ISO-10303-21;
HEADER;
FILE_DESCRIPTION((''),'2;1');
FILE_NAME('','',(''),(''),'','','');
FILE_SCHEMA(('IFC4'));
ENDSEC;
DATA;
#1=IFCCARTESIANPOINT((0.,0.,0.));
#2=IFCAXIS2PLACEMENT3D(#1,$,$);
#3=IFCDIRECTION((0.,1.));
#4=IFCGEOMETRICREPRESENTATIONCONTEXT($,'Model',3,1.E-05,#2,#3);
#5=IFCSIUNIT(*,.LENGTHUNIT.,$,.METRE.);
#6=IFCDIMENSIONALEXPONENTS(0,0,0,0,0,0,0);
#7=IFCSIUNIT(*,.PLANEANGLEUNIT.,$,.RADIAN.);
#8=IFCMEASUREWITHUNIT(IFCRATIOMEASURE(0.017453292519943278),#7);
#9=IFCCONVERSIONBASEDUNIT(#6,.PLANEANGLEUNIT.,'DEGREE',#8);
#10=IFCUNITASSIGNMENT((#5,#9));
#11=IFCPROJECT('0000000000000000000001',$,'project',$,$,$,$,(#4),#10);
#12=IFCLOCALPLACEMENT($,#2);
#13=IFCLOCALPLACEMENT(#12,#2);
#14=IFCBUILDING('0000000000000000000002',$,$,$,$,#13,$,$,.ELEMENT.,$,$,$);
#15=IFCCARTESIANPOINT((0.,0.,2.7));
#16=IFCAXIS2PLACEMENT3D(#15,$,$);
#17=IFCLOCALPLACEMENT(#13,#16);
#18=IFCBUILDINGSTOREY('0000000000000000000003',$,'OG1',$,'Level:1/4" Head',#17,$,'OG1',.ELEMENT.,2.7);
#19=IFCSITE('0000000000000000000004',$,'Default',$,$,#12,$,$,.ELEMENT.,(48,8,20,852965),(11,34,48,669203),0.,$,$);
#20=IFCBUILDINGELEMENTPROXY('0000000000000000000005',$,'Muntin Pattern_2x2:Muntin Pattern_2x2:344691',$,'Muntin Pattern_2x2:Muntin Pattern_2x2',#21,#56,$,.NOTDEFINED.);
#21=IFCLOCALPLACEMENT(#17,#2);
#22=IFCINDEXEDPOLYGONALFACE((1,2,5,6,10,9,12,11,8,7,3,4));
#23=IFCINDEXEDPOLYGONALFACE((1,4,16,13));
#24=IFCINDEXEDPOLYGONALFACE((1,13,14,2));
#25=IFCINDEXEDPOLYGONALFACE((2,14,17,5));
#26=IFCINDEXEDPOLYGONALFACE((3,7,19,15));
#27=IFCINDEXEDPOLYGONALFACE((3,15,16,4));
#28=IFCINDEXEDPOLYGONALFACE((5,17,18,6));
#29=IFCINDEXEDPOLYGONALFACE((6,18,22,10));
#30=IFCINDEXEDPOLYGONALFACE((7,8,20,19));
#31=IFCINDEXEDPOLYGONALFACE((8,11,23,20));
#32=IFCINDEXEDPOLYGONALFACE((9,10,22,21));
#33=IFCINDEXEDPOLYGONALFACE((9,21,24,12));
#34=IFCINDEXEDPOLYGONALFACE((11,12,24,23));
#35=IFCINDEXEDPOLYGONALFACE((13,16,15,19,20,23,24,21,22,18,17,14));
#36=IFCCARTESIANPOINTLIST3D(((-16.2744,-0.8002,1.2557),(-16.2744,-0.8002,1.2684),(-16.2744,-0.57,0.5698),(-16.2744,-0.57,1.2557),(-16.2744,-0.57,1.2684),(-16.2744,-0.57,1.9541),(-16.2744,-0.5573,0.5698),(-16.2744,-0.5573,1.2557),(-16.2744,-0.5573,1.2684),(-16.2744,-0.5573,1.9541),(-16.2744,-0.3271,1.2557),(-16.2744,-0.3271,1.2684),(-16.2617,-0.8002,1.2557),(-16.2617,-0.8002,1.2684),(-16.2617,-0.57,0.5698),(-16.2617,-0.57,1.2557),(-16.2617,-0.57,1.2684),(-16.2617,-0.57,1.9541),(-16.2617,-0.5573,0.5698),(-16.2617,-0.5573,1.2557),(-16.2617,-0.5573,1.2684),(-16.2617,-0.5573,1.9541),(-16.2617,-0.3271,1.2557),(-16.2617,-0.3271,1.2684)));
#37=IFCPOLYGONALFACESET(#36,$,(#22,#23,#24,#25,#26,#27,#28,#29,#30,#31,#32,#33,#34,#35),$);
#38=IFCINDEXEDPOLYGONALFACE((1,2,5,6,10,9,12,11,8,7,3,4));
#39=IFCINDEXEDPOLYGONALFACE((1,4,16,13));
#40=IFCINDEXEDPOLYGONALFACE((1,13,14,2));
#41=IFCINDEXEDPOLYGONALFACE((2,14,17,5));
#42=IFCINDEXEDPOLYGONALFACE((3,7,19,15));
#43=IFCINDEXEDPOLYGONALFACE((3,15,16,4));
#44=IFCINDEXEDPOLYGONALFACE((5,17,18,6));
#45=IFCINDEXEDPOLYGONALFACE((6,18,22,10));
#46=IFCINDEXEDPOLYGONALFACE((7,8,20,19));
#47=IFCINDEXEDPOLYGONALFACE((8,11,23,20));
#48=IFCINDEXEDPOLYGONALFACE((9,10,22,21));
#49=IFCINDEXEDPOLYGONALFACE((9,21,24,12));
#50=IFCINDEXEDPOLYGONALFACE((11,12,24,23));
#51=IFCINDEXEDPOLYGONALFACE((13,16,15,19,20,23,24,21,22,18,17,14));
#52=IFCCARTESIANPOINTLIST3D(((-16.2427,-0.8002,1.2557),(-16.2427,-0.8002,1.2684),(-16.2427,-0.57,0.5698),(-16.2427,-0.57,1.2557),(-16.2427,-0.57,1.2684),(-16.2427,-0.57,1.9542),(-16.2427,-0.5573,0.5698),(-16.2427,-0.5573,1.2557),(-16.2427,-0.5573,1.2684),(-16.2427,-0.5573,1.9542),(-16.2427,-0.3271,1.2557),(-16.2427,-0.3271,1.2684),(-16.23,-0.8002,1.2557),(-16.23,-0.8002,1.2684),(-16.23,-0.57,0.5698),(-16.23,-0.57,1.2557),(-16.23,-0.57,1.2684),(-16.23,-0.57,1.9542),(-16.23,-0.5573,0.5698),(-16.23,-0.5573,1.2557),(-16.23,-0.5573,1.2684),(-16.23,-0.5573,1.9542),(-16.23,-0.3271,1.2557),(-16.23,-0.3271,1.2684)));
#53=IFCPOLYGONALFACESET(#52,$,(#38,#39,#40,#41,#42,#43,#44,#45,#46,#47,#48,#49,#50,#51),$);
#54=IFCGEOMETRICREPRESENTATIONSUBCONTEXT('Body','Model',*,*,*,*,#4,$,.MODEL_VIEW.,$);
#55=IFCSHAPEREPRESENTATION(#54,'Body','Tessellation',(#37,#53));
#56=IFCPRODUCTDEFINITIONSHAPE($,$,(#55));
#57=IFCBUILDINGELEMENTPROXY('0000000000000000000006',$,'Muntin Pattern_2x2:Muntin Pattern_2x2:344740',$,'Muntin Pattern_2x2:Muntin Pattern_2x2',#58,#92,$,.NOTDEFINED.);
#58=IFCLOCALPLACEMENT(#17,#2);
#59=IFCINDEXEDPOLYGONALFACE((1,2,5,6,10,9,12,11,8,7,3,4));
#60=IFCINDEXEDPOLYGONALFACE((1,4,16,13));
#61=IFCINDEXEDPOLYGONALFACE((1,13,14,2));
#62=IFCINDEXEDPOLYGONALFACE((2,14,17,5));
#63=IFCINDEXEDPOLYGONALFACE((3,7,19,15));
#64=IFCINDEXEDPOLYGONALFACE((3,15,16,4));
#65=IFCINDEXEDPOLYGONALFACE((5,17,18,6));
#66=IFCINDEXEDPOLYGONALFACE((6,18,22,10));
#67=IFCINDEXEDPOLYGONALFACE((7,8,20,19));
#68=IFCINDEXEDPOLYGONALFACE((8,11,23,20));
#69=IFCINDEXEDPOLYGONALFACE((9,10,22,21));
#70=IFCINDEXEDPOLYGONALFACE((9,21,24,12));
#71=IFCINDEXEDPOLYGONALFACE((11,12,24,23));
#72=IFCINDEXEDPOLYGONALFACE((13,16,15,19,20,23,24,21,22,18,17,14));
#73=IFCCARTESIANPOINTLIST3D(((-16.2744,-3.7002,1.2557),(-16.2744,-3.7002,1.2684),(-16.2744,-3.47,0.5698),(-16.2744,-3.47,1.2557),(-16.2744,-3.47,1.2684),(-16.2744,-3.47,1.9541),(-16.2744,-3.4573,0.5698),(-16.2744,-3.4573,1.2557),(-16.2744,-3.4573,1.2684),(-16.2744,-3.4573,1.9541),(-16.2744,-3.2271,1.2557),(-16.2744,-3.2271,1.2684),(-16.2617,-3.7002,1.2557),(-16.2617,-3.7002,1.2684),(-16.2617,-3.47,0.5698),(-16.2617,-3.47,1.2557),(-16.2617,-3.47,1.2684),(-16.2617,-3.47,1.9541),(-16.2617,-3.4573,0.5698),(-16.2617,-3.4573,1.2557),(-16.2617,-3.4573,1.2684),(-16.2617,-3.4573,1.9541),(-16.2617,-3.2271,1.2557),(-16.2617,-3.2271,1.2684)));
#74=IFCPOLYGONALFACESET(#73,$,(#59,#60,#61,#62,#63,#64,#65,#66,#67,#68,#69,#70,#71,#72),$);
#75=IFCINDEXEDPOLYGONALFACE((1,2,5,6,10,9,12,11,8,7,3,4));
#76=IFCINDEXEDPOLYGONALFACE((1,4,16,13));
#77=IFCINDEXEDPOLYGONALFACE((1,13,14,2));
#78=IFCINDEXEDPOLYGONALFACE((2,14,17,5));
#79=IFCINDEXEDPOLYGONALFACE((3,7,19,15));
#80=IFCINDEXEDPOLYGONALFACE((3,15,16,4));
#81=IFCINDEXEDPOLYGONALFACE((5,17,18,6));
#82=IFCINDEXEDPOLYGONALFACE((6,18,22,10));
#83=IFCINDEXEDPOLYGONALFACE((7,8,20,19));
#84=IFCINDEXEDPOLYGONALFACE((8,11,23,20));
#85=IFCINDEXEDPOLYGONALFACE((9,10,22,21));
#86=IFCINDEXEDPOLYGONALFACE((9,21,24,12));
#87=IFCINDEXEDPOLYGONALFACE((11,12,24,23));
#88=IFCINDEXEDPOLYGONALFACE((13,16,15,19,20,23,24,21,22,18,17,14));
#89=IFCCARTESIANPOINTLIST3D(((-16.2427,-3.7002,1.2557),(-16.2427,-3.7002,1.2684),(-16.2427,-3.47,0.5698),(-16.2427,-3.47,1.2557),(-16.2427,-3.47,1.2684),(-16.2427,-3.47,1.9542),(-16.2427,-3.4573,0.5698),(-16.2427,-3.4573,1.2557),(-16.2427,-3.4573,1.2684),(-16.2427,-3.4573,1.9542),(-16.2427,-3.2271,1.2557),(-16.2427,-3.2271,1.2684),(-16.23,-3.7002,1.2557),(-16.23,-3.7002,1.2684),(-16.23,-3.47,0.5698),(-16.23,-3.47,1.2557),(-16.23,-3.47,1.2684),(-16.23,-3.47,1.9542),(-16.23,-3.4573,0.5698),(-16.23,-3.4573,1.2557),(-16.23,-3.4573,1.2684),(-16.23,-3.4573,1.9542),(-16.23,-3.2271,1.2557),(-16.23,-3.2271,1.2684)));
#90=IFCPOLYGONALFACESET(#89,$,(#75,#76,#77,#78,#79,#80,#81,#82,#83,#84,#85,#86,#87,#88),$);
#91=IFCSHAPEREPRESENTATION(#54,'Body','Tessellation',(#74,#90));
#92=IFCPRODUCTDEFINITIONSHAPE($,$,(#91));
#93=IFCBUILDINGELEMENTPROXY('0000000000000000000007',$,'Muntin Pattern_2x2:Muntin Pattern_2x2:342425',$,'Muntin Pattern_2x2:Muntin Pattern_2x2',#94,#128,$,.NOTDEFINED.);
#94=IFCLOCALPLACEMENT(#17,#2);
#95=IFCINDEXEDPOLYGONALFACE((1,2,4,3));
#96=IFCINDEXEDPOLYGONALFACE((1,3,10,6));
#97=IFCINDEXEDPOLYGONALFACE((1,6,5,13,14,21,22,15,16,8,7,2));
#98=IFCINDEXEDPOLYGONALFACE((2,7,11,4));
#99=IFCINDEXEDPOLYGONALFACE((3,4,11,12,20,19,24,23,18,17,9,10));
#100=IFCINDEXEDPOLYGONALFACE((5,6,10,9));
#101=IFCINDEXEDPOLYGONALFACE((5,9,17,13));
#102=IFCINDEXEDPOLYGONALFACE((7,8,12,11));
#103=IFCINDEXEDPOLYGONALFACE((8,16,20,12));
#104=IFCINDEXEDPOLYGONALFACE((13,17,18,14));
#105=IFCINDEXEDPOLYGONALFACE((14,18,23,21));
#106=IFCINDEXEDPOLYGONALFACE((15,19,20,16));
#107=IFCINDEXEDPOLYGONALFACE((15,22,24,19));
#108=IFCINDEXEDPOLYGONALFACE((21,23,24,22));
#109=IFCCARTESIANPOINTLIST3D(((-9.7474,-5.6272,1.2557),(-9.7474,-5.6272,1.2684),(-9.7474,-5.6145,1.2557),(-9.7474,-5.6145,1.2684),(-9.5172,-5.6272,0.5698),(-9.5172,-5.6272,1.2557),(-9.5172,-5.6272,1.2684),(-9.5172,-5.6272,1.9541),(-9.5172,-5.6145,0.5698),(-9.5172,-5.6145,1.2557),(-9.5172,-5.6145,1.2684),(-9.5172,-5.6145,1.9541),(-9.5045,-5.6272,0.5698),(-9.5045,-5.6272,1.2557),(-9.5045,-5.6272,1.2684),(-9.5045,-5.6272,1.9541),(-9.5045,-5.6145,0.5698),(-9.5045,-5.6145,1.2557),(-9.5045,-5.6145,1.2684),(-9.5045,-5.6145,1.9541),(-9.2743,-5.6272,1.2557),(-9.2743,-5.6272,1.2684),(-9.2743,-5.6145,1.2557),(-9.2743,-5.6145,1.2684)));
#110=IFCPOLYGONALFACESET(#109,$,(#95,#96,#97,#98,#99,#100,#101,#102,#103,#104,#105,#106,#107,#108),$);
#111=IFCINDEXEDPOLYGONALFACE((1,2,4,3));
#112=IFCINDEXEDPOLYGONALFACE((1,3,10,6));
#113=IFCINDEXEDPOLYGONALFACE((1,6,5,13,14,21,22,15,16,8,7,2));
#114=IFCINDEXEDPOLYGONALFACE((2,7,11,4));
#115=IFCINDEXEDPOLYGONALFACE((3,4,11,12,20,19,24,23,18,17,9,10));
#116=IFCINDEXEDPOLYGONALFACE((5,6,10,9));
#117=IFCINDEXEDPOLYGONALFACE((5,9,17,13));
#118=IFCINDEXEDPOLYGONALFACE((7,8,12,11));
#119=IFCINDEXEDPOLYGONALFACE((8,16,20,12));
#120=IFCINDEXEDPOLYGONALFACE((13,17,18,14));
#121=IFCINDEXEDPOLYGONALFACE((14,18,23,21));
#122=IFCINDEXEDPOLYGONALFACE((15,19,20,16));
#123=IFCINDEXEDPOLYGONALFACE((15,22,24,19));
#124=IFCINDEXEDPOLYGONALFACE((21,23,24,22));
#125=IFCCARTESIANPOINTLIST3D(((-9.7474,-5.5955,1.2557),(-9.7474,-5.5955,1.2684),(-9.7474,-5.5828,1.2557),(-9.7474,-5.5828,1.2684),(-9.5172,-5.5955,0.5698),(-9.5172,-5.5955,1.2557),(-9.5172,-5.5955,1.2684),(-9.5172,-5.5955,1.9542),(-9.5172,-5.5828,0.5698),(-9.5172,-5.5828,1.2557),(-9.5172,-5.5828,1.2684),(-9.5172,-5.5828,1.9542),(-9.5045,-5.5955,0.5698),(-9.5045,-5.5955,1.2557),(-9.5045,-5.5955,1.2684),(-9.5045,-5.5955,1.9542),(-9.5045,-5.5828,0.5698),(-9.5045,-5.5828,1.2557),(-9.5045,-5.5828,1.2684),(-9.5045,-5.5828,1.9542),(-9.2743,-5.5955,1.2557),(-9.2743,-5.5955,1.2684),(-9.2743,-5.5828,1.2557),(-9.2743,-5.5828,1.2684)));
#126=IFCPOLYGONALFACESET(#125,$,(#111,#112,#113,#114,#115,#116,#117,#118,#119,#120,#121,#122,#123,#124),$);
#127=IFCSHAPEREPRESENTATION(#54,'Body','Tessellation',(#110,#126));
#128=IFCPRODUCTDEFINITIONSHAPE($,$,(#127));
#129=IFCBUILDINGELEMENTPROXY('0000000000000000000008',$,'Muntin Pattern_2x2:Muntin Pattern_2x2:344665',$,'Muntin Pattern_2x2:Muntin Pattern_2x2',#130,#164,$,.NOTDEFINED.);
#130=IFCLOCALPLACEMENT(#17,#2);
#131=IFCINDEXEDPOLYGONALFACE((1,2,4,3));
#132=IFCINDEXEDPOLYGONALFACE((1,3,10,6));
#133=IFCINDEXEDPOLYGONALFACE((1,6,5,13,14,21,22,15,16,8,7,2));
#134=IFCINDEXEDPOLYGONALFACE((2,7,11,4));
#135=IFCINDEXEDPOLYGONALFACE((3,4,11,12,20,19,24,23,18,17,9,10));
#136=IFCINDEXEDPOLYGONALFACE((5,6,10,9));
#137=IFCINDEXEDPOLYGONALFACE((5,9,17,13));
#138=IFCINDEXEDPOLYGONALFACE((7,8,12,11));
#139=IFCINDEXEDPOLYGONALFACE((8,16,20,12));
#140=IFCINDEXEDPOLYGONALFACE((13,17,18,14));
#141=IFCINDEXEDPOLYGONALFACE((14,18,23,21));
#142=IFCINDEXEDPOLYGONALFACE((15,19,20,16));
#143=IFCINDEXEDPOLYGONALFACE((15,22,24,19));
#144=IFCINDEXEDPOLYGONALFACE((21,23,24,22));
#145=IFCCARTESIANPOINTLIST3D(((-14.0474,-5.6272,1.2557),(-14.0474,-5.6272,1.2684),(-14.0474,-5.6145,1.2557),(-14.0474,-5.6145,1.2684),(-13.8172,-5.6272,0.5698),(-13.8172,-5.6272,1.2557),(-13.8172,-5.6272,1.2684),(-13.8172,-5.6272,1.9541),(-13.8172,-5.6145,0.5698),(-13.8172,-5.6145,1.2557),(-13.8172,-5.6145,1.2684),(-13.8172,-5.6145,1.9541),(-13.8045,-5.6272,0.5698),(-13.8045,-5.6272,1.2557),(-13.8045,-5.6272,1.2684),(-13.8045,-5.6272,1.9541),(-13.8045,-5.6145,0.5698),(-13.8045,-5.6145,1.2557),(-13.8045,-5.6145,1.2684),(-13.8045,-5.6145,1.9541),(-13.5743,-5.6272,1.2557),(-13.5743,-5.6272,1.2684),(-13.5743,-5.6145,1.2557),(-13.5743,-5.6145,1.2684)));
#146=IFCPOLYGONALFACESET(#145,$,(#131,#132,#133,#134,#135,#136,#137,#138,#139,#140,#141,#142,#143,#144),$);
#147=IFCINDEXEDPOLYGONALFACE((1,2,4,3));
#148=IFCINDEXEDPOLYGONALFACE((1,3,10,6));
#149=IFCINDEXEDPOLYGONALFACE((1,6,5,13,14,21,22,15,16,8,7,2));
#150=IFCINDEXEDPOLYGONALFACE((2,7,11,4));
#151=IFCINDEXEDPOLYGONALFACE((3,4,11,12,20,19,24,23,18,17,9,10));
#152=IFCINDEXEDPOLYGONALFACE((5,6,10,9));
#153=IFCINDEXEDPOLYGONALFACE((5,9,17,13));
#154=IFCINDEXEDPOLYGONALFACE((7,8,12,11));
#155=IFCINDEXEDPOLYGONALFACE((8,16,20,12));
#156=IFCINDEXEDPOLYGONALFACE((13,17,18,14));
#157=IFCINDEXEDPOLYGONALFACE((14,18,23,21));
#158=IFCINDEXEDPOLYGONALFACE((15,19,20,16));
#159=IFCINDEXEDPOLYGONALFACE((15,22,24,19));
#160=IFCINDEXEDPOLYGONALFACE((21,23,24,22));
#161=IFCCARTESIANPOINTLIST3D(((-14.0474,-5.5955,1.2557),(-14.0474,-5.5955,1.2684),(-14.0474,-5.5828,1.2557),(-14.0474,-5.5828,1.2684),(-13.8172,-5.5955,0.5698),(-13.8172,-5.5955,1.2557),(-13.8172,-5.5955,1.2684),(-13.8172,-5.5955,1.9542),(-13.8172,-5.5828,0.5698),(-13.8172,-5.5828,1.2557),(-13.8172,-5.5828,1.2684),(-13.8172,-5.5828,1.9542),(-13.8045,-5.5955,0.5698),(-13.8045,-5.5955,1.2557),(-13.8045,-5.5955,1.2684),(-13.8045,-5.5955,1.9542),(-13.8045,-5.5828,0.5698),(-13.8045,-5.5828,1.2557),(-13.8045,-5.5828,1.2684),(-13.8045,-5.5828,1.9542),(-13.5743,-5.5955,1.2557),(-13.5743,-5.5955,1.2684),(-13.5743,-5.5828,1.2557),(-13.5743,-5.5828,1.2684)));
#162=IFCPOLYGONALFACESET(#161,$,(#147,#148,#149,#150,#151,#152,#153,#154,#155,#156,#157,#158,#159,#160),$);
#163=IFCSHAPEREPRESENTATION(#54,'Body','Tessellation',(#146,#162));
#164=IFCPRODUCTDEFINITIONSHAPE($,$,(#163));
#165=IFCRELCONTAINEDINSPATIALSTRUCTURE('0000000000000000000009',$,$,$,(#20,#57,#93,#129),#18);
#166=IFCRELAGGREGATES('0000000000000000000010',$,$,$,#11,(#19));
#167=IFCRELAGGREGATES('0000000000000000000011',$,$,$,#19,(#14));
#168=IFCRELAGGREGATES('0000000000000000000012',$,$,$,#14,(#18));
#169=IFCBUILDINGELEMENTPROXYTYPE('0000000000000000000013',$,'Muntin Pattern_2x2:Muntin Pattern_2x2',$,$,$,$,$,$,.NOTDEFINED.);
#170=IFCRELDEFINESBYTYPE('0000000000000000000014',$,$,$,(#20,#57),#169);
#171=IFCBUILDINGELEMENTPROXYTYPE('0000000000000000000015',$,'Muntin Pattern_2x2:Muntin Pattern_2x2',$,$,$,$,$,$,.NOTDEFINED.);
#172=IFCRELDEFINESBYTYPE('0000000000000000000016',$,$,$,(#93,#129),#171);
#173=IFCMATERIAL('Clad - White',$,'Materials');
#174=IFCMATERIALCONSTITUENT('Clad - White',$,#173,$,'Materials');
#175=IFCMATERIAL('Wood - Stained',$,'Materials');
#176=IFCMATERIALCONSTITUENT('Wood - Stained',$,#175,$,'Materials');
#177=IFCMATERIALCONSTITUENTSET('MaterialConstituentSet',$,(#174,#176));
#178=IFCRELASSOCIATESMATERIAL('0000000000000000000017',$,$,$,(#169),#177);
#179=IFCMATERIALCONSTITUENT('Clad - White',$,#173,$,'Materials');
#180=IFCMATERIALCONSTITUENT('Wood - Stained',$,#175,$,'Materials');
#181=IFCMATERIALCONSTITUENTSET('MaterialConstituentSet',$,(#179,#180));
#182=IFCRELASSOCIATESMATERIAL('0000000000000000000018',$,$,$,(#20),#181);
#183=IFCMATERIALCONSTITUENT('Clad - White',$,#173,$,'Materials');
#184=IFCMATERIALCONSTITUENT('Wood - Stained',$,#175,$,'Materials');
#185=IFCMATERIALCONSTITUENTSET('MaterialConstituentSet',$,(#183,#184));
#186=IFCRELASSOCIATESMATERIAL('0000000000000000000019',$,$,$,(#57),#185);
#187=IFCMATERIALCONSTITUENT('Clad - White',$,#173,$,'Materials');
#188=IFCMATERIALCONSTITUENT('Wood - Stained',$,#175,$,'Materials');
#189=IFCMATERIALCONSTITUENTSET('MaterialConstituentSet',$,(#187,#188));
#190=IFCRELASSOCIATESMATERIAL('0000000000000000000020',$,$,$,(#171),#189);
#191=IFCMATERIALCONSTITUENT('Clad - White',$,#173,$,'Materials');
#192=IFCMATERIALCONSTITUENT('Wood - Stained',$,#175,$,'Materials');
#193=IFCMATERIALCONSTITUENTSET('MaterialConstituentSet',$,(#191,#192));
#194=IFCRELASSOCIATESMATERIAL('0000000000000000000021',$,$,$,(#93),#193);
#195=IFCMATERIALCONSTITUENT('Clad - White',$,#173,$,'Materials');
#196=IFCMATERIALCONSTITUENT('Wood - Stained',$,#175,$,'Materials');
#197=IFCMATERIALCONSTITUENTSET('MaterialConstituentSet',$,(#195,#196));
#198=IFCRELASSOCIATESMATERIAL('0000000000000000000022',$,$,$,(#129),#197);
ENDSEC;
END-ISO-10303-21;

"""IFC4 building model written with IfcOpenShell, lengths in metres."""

from ifc_helpers import new_model, entity, si_unit, converted_unit, direction, frame, origin, place, context, subcontext, project, spatial, indexed_curve, outline, extrude, source, transform, mapped, material, constituent, constituent_set, type_object, type_shapes, element, save


model = new_model("IFC4")

# Units and contexts
model_context = context("Model", 3, precision=1e-05, world=origin(), true_north=direction((0.0, 1.0)))
body_context = subcontext(model_context, "Body", "Model", "MODEL_VIEW")
ifc_project = project(units=[si_unit("LENGTHUNIT", "METRE"), converted_unit("PLANEANGLEUNIT", "DEGREE", entity("IfcRatioMeasure", 0.017453292519943278), si_unit("PLANEANGLEUNIT", "RADIAN"), dimensions=[0, 0, 0, 0, 0, 0, 0])], contexts=[model_context])

# Site, building, storey
site_placement = place(None, origin())
site = spatial("IfcSite", under=ifc_project, at=site_placement, Name="Default", CompositionType="ELEMENT", RefLatitude=(48, 8, 20, 852965), RefLongitude=(11, 34, 48, 669203), RefElevation=0.0)
building_placement = place(site_placement, origin())
building = spatial("IfcBuilding", under=site, at=building_placement, CompositionType="ELEMENT")
storey_placement = place(building_placement, frame((0.0, 0.0, 2.7)))
storey = spatial("IfcBuildingStorey", under=building, at=storey_placement, Name="OG1", ObjectType="Level:1/4\" Head", LongName="OG1", CompositionType="ELEMENT", Elevation=2.7)

# Building element proxies
ifc_material_1 = material(Name="Clad - White", Category="Materials")
ifc_material_2 = material(Name="Wood - Stained", Category="Materials")
ifc_constituent_1 = constituent(ifc_material_1, Name="Clad - White", Category="Materials")
ifc_constituent_2 = constituent(ifc_material_2, Name="Wood - Stained", Category="Materials")
ifc_constituent_set_1 = constituent_set(constituents=[ifc_constituent_1, ifc_constituent_2], Name="MaterialConstituentSet")
building_element_proxy_type_1 = type_object("IfcBuildingElementProxyType", Name="Muntin Pattern_2x2:Muntin Pattern_2x2", PredefinedType="NOTDEFINED", material=ifc_constituent_set_1)
shared_shape_1 = source(origin(), body_context, "Body", "SweptSolid", [
    extrude(outline(indexed_curve([(0.0064, -0.0064), (0.6921, -0.0064), (0.6921, 0.0063), (0.0064, 0.0063), (0.0064, 0.2365), (-0.0063, 0.2365), (-0.0063, 0.0063), (-0.6922, 0.0063), (-0.6922, -0.0064), (-0.0063, -0.0064), (-0.0063, -0.2365), (0.0064, -0.2365), (0.0064, -0.0064)], self_intersect=False)), frame((0.0, -0.0222, 0.6921), z_axis=(0.0, 1.0, 0.0), x_axis=(0.0, 0.0, 1.0)), (0.0, 0.0, 1.0), 0.0127),
    extrude(outline(indexed_curve([(0.0064, -0.0064), (0.6922, -0.0064), (0.6922, 0.0063), (0.0064, 0.0063), (0.0064, 0.2365), (-0.0063, 0.2365), (-0.0063, 0.0063), (-0.6922, 0.0063), (-0.6922, -0.0064), (-0.0063, -0.0064), (-0.0063, -0.2365), (0.0064, -0.2365), (0.0064, -0.0064)], self_intersect=False)), frame((0.0, 0.0095, 0.6922), z_axis=(0.0, 1.0, 0.0), x_axis=(0.0, 0.0, 1.0)), (0.0, 0.0, 1.0), 0.0127),
])
type_shapes(building_element_proxy_type_1, [shared_shape_1])
ifc_constituent_3 = constituent(ifc_material_1, Name="Clad - White", Category="Materials")
ifc_constituent_4 = constituent(ifc_material_2, Name="Wood - Stained", Category="Materials")
ifc_constituent_set_2 = constituent_set(constituents=[ifc_constituent_3, ifc_constituent_4], Name="MaterialConstituentSet")
proxy_1_placement = place(storey_placement, frame((-16.2522, -0.5636, 0.5699), z_axis=(0.0, 0.0, 1.0), x_axis=(0.0, -1.0, 0.0)))
element("IfcBuildingElementProxy", 1, at=proxy_1_placement, inside=storey, type_object=building_element_proxy_type_1, material=ifc_constituent_set_2, Name="Muntin Pattern_2x2:Muntin Pattern_2x2:344691", ObjectType="Muntin Pattern_2x2:Muntin Pattern_2x2", PredefinedType="NOTDEFINED", context=body_context, shape_type="MappedRepresentation", body=[
    mapped(shared_shape_1, transform((0.0, 0.0, 0.0), scale=1.0)),
])
ifc_constituent_5 = constituent(ifc_material_1, Name="Clad - White", Category="Materials")
ifc_constituent_6 = constituent(ifc_material_2, Name="Wood - Stained", Category="Materials")
ifc_constituent_set_3 = constituent_set(constituents=[ifc_constituent_5, ifc_constituent_6], Name="MaterialConstituentSet")
proxy_2_placement = place(storey_placement, frame((-16.2522, -3.4636, 0.5699), z_axis=(0.0, 0.0, 1.0), x_axis=(0.0, -1.0, 0.0)))
element("IfcBuildingElementProxy", 2, at=proxy_2_placement, inside=storey, type_object=building_element_proxy_type_1, material=ifc_constituent_set_3, Name="Muntin Pattern_2x2:Muntin Pattern_2x2:344740", ObjectType="Muntin Pattern_2x2:Muntin Pattern_2x2", PredefinedType="NOTDEFINED", context=body_context, shape_type="MappedRepresentation", body=[
    mapped(shared_shape_1, transform((0.0, 0.0, 0.0), scale=1.0)),
])
ifc_constituent_7 = constituent(ifc_material_1, Name="Clad - White", Category="Materials")
ifc_constituent_8 = constituent(ifc_material_2, Name="Wood - Stained", Category="Materials")
ifc_constituent_set_4 = constituent_set(constituents=[ifc_constituent_7, ifc_constituent_8], Name="MaterialConstituentSet")
ifc_constituent_9 = constituent(ifc_material_1, Name="Clad - White", Category="Materials")
ifc_constituent_10 = constituent(ifc_material_2, Name="Wood - Stained", Category="Materials")
ifc_constituent_set_5 = constituent_set(constituents=[ifc_constituent_9, ifc_constituent_10], Name="MaterialConstituentSet")
building_element_proxy_type_2 = type_object("IfcBuildingElementProxyType", Name="Muntin Pattern_2x2:Muntin Pattern_2x2", PredefinedType="NOTDEFINED", material=ifc_constituent_set_5)
shared_shape_2 = source(origin(), body_context, "Body", "SweptSolid", [
    extrude(outline(indexed_curve([(0.0064, -0.0064), (0.6921, -0.0064), (0.6921, 0.0063), (0.0064, 0.0063), (0.0064, 0.2365), (-0.0063, 0.2365), (-0.0063, 0.0063), (-0.6922, 0.0063), (-0.6922, -0.0064), (-0.0063, -0.0064), (-0.0063, -0.2365), (0.0064, -0.2365), (0.0064, -0.0064)], self_intersect=False)), frame((0.0, 0.0095, 0.6921), z_axis=(0.0, 1.0, 0.0), x_axis=(0.0, 0.0, 1.0)), (0.0, 0.0, 1.0), 0.0127),
    extrude(outline(indexed_curve([(0.0064, -0.0064), (0.6922, -0.0064), (0.6922, 0.0063), (0.0064, 0.0063), (0.0064, 0.2365), (-0.0063, 0.2365), (-0.0063, 0.0063), (-0.6922, 0.0063), (-0.6922, -0.0064), (-0.0063, -0.0064), (-0.0063, -0.2365), (0.0064, -0.2365), (0.0064, -0.0064)], self_intersect=False)), frame((0.0, -0.0222, 0.6922), z_axis=(0.0, 1.0, 0.0), x_axis=(0.0, 0.0, 1.0)), (0.0, 0.0, 1.0), 0.0127),
])
type_shapes(building_element_proxy_type_2, [shared_shape_2])
proxy_3_placement = place(storey_placement, frame((-9.5108, -5.605, 0.5699), z_axis=(0.0, 0.0, 1.0), x_axis=(-1.0, 0.0, 0.0)))
element("IfcBuildingElementProxy", 3, at=proxy_3_placement, inside=storey, type_object=building_element_proxy_type_2, material=ifc_constituent_set_4, Name="Muntin Pattern_2x2:Muntin Pattern_2x2:342425", ObjectType="Muntin Pattern_2x2:Muntin Pattern_2x2", PredefinedType="NOTDEFINED", context=body_context, shape_type="MappedRepresentation", body=[
    mapped(shared_shape_2, transform((0.0, 0.0, 0.0), scale=1.0)),
])
ifc_constituent_11 = constituent(ifc_material_1, Name="Clad - White", Category="Materials")
ifc_constituent_12 = constituent(ifc_material_2, Name="Wood - Stained", Category="Materials")
ifc_constituent_set_6 = constituent_set(constituents=[ifc_constituent_11, ifc_constituent_12], Name="MaterialConstituentSet")
proxy_4_placement = place(storey_placement, frame((-13.8108, -5.605, 0.5699), z_axis=(0.0, 0.0, 1.0), x_axis=(-1.0, 0.0, 0.0)))
element("IfcBuildingElementProxy", 4, at=proxy_4_placement, inside=storey, type_object=building_element_proxy_type_2, material=ifc_constituent_set_6, Name="Muntin Pattern_2x2:Muntin Pattern_2x2:344665", ObjectType="Muntin Pattern_2x2:Muntin Pattern_2x2", PredefinedType="NOTDEFINED", context=body_context, shape_type="MappedRepresentation", body=[
    mapped(shared_shape_2, transform((0.0, 0.0, 0.0), scale=1.0)),
])

save(model, "model.ifc")
